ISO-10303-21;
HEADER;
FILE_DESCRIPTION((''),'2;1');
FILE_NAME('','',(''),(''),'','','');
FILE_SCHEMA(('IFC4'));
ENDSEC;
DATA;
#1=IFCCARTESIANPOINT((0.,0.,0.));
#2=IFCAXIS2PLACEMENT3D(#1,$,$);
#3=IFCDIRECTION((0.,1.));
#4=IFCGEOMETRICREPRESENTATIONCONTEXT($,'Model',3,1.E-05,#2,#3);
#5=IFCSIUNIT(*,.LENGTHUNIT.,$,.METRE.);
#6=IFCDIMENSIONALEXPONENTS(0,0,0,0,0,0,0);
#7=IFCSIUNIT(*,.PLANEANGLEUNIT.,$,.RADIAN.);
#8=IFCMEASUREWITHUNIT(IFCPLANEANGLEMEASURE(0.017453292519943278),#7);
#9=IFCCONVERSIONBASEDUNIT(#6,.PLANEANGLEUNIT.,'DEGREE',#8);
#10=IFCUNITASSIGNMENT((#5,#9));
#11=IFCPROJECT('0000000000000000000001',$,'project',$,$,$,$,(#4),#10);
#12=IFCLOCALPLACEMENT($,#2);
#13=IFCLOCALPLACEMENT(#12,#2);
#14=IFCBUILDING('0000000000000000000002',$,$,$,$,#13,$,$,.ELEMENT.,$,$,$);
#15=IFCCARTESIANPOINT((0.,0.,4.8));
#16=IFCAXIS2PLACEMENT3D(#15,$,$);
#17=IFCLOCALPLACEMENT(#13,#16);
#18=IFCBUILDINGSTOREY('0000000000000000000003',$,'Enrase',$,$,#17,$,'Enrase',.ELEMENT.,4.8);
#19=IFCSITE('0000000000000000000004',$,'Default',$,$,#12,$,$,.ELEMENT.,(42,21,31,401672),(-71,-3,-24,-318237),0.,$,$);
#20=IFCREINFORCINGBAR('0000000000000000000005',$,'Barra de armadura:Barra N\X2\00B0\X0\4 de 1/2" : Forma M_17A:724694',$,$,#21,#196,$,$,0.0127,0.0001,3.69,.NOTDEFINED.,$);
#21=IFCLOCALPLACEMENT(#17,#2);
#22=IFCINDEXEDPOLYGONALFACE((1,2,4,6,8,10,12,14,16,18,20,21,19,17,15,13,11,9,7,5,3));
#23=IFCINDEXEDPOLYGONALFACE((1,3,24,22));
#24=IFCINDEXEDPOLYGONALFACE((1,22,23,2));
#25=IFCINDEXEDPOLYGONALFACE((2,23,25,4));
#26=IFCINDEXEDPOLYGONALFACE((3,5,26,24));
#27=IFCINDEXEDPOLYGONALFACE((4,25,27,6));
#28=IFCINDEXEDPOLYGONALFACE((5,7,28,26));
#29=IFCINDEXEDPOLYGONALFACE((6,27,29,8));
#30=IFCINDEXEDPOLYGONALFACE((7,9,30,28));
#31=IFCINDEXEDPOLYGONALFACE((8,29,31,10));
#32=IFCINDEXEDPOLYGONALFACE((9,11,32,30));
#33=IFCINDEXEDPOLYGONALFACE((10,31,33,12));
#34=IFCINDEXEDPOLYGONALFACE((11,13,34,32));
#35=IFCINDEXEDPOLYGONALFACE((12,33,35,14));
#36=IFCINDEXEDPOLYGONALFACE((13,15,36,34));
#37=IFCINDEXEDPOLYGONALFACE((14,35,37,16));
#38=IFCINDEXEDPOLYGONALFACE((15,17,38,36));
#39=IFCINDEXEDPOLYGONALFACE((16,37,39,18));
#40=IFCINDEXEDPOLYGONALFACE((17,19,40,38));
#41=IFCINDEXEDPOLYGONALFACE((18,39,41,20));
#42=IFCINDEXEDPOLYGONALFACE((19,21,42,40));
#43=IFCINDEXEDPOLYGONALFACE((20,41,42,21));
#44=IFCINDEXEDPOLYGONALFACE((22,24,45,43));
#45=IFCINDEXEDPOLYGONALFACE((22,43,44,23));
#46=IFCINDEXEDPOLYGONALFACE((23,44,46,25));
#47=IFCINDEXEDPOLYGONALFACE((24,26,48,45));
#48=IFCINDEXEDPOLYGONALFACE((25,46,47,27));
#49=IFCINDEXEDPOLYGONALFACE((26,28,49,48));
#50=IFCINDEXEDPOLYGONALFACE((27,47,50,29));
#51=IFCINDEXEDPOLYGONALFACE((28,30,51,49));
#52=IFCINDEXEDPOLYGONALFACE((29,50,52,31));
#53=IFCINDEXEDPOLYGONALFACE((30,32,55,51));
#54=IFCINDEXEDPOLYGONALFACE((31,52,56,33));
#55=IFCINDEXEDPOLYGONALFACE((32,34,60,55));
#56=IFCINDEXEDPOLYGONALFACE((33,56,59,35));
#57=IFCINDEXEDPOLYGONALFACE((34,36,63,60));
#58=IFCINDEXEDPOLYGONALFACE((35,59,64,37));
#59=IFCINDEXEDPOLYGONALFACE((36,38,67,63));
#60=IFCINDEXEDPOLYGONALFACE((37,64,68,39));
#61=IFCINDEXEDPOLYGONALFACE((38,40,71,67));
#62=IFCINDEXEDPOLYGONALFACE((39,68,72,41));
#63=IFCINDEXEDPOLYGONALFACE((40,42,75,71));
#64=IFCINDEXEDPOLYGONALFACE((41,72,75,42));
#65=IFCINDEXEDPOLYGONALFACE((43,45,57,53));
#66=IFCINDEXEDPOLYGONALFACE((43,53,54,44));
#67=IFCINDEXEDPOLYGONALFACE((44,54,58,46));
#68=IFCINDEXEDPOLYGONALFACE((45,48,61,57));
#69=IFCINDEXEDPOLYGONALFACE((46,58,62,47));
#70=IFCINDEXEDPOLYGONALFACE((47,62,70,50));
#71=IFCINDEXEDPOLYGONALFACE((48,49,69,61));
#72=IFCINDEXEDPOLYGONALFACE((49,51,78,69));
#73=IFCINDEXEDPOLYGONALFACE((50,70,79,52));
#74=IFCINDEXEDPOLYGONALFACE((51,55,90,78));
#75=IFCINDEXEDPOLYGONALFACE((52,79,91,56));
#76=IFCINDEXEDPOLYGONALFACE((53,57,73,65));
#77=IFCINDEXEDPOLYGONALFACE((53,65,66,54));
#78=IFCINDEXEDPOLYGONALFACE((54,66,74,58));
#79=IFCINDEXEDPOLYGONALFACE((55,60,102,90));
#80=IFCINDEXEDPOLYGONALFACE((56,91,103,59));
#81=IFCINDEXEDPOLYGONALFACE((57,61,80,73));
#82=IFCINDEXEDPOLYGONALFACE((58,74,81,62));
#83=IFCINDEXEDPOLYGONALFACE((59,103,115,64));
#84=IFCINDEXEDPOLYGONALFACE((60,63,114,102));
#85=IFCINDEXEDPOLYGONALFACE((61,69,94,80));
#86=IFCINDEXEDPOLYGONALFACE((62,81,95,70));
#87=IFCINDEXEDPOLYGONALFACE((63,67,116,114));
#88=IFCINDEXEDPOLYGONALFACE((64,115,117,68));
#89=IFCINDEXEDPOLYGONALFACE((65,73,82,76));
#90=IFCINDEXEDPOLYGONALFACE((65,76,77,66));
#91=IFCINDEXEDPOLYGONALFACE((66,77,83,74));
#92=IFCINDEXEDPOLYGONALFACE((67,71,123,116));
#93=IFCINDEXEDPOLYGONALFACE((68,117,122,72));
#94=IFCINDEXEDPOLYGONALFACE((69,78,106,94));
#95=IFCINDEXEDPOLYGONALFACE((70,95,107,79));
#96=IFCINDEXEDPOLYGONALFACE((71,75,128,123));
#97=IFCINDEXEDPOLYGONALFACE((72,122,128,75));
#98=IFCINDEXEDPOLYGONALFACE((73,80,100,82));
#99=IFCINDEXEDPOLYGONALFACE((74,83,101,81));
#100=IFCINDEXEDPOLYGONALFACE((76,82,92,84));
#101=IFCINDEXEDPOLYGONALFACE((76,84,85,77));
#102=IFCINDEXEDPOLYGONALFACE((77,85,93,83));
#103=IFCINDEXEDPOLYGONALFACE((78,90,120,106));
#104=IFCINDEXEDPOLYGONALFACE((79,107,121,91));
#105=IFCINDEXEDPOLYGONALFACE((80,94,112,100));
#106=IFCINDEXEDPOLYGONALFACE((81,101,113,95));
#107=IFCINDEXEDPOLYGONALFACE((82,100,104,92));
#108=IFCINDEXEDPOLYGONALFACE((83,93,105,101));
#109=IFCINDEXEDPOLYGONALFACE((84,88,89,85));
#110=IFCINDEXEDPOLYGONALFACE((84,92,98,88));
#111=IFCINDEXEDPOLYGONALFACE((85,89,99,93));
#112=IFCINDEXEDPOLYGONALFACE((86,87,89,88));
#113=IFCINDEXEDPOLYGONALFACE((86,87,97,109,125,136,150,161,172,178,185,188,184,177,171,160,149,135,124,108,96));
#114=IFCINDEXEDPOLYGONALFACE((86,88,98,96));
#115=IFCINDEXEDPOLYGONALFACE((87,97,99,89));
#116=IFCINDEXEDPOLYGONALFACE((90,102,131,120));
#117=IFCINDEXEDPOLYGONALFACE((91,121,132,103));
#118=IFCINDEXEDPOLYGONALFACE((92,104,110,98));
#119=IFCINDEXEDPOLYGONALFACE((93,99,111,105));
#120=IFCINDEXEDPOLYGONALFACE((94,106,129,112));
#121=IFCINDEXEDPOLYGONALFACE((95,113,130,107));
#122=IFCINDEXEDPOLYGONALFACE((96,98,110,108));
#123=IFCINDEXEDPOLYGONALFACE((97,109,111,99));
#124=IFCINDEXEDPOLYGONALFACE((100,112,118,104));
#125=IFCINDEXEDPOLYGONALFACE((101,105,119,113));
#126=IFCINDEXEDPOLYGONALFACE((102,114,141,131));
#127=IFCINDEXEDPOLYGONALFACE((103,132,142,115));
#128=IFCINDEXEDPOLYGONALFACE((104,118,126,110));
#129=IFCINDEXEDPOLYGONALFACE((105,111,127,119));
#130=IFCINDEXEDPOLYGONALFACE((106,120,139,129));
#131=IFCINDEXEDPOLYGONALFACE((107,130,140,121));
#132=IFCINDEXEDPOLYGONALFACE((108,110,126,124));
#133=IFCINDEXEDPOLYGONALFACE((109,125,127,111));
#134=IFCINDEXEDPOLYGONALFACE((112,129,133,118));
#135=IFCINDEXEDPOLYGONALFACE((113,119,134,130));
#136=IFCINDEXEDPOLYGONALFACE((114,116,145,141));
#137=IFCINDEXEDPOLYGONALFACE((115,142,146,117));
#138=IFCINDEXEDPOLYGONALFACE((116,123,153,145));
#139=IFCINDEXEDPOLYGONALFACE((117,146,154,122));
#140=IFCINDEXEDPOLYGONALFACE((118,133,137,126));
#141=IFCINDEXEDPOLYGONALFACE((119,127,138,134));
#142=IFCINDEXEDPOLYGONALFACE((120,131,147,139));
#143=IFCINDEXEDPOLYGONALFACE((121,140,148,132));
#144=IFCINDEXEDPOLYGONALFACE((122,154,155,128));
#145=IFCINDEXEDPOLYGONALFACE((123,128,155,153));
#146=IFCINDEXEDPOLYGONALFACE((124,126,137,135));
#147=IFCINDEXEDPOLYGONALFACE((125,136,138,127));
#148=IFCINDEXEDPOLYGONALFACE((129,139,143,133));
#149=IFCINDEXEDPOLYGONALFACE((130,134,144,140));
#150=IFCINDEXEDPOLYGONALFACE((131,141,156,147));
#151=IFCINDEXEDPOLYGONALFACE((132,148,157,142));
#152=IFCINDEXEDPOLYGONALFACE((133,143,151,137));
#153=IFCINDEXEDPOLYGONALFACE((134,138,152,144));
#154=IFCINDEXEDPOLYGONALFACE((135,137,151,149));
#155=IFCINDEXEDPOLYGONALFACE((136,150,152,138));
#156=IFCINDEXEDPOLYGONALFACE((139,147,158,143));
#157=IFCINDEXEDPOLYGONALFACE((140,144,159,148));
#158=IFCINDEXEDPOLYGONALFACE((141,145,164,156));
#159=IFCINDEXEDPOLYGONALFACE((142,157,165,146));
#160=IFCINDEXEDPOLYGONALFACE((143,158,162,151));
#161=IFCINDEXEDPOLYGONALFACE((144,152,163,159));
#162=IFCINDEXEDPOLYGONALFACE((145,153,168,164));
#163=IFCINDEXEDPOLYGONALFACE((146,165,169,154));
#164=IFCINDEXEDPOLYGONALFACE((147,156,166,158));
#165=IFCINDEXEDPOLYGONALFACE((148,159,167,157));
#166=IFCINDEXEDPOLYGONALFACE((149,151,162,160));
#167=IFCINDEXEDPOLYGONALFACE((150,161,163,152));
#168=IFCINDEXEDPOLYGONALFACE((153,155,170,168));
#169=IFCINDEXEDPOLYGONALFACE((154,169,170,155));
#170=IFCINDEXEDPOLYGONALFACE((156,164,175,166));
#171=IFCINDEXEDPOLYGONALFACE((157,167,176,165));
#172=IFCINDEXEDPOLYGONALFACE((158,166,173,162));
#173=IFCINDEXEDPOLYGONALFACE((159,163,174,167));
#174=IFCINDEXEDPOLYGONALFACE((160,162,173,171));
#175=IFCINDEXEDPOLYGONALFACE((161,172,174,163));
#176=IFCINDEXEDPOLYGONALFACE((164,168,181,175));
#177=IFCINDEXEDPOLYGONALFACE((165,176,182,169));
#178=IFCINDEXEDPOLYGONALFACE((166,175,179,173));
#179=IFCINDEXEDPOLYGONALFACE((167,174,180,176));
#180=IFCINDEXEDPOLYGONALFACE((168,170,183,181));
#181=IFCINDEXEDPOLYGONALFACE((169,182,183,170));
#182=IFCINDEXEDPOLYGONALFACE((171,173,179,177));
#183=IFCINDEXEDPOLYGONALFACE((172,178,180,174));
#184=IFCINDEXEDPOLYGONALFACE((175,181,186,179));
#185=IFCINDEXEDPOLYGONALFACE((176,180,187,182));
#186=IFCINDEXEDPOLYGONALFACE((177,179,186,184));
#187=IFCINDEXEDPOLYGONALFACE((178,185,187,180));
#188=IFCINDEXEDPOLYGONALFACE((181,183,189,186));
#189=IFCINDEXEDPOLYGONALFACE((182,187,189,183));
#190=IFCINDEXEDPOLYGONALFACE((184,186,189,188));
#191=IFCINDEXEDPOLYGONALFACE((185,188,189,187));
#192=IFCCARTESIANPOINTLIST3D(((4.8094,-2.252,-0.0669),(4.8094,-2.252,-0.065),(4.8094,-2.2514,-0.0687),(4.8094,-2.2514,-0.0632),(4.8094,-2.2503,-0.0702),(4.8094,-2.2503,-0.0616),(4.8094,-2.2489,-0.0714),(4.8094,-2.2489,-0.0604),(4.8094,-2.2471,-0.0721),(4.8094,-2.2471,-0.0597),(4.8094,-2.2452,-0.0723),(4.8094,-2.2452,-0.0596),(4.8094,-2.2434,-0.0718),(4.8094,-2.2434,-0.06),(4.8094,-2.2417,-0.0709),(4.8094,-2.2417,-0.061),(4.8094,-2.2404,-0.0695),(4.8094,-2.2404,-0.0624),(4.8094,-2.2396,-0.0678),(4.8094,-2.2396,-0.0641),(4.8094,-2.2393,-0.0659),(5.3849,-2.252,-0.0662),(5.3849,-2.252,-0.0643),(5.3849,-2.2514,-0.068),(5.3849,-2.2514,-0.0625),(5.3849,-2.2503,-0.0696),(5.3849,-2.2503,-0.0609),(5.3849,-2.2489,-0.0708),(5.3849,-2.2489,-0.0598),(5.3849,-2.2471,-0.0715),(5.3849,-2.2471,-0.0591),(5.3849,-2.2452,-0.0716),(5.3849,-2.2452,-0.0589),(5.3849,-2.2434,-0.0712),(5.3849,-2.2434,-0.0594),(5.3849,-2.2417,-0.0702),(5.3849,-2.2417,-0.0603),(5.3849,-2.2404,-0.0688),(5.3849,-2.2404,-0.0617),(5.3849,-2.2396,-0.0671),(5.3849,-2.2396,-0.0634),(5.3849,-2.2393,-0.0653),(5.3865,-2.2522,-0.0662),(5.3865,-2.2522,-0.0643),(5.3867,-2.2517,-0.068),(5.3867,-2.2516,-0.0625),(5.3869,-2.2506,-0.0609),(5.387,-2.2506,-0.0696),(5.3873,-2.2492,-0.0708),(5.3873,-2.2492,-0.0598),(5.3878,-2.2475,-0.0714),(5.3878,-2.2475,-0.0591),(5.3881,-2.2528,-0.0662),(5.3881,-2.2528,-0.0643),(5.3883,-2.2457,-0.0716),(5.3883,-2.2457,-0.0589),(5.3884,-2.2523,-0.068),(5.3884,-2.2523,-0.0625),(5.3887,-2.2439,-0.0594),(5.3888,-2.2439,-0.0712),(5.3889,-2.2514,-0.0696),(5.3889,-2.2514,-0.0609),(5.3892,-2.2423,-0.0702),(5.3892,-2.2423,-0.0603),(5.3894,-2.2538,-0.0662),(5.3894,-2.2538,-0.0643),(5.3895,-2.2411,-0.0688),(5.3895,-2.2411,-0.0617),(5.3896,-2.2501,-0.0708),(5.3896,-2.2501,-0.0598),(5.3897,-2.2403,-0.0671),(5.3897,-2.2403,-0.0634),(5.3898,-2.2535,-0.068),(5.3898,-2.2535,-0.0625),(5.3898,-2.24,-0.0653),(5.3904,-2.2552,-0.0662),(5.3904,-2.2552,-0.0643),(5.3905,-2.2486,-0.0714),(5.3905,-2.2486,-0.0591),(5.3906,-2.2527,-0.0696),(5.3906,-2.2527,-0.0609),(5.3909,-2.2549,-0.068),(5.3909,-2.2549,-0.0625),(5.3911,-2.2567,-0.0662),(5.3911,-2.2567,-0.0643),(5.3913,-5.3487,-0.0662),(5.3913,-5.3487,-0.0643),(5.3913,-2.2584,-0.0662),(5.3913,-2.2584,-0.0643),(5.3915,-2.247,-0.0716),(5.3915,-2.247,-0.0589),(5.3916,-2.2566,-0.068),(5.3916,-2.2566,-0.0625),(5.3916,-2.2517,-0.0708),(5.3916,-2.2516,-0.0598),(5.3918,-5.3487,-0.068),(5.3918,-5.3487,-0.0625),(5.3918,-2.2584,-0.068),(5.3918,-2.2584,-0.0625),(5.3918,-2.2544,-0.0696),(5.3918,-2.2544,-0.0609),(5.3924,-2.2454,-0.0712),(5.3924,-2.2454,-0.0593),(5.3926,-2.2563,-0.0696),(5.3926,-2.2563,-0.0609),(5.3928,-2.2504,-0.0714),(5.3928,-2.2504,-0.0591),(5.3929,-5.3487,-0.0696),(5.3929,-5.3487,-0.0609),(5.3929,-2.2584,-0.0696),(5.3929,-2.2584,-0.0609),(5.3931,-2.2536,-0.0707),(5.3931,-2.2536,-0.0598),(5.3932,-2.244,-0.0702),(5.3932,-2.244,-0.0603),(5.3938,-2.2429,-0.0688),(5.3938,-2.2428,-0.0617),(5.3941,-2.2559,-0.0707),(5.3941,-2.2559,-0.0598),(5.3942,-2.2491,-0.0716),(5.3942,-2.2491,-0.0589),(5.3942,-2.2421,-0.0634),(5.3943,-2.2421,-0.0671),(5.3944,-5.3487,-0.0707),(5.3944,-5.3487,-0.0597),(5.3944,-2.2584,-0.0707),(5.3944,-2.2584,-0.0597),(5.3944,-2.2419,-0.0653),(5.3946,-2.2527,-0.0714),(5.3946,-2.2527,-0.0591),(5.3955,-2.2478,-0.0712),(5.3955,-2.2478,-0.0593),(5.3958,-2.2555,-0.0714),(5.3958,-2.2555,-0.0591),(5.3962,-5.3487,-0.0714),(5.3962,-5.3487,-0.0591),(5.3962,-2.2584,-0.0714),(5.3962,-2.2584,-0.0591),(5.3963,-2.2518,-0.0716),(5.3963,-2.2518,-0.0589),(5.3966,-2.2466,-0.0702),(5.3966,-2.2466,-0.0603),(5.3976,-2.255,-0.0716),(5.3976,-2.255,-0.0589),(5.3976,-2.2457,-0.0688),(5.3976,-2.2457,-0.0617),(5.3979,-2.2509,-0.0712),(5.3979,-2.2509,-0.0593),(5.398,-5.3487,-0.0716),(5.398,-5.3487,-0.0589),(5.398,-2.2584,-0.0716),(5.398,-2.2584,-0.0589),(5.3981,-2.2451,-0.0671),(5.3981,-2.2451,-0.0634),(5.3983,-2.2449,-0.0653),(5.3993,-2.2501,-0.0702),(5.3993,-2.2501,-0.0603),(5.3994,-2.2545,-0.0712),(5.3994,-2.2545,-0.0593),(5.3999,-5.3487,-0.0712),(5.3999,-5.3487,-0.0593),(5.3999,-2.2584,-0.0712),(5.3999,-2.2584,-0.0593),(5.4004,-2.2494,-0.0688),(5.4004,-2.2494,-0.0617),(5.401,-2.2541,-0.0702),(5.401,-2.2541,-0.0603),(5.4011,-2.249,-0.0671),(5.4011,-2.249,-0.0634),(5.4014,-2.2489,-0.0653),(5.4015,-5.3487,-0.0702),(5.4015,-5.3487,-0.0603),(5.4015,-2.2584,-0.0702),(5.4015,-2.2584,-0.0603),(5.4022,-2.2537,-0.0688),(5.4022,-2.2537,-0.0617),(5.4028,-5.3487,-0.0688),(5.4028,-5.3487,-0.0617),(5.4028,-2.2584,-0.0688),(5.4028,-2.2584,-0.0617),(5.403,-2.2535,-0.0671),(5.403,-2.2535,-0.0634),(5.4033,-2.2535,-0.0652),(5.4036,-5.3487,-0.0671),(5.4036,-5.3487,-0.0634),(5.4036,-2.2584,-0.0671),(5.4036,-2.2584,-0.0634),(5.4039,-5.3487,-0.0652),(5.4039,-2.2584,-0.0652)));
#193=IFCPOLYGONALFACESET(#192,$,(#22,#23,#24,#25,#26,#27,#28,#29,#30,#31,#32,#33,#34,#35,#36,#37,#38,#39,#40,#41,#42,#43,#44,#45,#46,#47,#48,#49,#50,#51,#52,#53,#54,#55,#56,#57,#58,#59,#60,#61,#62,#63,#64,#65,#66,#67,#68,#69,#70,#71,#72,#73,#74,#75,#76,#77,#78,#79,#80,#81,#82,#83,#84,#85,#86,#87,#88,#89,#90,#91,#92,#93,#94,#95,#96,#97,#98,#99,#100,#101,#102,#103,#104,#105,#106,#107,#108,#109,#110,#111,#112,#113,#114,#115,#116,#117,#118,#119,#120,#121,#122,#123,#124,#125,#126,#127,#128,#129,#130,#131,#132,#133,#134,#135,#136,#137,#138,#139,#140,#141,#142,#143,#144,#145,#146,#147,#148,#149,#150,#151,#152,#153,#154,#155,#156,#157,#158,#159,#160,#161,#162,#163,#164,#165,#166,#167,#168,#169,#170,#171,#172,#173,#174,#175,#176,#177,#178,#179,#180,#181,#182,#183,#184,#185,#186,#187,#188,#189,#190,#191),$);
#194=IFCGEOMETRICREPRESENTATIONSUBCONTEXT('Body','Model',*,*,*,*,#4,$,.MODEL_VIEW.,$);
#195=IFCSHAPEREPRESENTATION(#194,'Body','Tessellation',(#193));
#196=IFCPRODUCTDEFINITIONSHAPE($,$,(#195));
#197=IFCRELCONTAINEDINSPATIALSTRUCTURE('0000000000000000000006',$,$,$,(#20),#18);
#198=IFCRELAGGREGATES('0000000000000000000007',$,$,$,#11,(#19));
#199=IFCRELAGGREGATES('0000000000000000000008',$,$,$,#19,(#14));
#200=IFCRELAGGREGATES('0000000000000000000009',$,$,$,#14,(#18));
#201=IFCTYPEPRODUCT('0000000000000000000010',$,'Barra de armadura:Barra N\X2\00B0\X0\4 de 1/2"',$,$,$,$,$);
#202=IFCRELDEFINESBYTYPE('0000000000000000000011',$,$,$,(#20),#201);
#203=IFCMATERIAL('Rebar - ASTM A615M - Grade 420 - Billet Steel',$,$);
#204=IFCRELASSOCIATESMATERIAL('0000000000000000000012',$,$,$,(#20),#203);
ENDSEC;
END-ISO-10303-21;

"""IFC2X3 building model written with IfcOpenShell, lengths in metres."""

from ifc_helpers import new_model, entity, si_unit, converted_unit, direction, frame, origin, place, context, subcontext, project, spatial, material, type_object, element, save


model = new_model("IFC2X3")

# Units and contexts
model_context = context("Model", 3, precision=1e-05, world=origin(), true_north=direction((0.0, 1.0)))
body_context = subcontext(model_context, "Body", "Model", "MODEL_VIEW")
ifc_project = project(units=[si_unit("LENGTHUNIT", "METRE"), converted_unit("PLANEANGLEUNIT", "DEGREE", entity("IfcPlaneAngleMeasure", 0.017453292519943278), si_unit("PLANEANGLEUNIT", "RADIAN"), dimensions=[0, 0, 0, 0, 0, 0, 0])], contexts=[model_context])

# Site, building, storey
site_placement = place(None, origin())
site = spatial("IfcSite", under=ifc_project, at=site_placement, Name="Default", CompositionType="ELEMENT", RefLatitude=(42, 21, 31, 401672), RefLongitude=(-71, -3, -24, -318237), RefElevation=0.0)
building_placement = place(site_placement, origin())
building = spatial("IfcBuilding", under=site, at=building_placement, CompositionType="ELEMENT")
storey_placement = place(building_placement, frame((0.0, 0.0, 4.8)))
storey = spatial("IfcBuildingStorey", under=building, at=storey_placement, Name="Enrase", LongName="Enrase", CompositionType="ELEMENT", Elevation=4.8)

# Reinforcing bar
ifc_material = material(Name="Rebar - ASTM A615M - Grade 420 - Billet Steel")
type_product_1 = type_object("IfcTypeProduct", Name="Barra de armadura:Barra N°4 de 1/2\"")
reinforcing_bar_1_placement = place(storey_placement, origin())
element("IfcReinforcingBar", 1, at=reinforcing_bar_1_placement, inside=storey, type_object=type_product_1, material=ifc_material, Name="Barra de armadura:Barra N°4 de 1/2\" : Forma M_17A:724694", BarLength=3.69, BarRole="NOTDEFINED", CrossSectionArea=0.0001, NominalDiameter=0.0127, context=body_context, shape_type="AdvancedSweptSolid", body=[
    entity("IfcSweptDiskSolid", entity("IfcCompositeCurve", [entity("IfcCompositeCurveSegment", "CONTINUOUS", True, entity("IfcPolyline", [entity("IfcCartesianPoint", [5.3976, -5.3487, -0.0652]), entity("IfcCartesianPoint", [5.3976, -2.2584, -0.0652])])), entity("IfcCompositeCurveSegment", "CONTINUOUS", True, entity("IfcTrimmedCurve", entity("IfcCircle", entity("IfcAxis2Placement3D", entity("IfcCartesianPoint", [5.3849, -2.2584, -0.0653]), entity("IfcDirection", [-0.001144, 0.0, 0.999999]), entity("IfcDirection", [0.0, 1.0, 0.0])), 0.0127), [entity("IfcParameterValue", 270.0)], [entity("IfcParameterValue", 360.0)], True, "PARAMETER")), entity("IfcCompositeCurveSegment", "CONTINUOUS", True, entity("IfcPolyline", [entity("IfcCartesianPoint", [5.3849, -2.2457, -0.0653]), entity("IfcCartesianPoint", [4.8094, -2.2457, -0.0659])]))], False), 0.0063, None, 0.0, 92.0),
])

save(model, "model.ifc")
